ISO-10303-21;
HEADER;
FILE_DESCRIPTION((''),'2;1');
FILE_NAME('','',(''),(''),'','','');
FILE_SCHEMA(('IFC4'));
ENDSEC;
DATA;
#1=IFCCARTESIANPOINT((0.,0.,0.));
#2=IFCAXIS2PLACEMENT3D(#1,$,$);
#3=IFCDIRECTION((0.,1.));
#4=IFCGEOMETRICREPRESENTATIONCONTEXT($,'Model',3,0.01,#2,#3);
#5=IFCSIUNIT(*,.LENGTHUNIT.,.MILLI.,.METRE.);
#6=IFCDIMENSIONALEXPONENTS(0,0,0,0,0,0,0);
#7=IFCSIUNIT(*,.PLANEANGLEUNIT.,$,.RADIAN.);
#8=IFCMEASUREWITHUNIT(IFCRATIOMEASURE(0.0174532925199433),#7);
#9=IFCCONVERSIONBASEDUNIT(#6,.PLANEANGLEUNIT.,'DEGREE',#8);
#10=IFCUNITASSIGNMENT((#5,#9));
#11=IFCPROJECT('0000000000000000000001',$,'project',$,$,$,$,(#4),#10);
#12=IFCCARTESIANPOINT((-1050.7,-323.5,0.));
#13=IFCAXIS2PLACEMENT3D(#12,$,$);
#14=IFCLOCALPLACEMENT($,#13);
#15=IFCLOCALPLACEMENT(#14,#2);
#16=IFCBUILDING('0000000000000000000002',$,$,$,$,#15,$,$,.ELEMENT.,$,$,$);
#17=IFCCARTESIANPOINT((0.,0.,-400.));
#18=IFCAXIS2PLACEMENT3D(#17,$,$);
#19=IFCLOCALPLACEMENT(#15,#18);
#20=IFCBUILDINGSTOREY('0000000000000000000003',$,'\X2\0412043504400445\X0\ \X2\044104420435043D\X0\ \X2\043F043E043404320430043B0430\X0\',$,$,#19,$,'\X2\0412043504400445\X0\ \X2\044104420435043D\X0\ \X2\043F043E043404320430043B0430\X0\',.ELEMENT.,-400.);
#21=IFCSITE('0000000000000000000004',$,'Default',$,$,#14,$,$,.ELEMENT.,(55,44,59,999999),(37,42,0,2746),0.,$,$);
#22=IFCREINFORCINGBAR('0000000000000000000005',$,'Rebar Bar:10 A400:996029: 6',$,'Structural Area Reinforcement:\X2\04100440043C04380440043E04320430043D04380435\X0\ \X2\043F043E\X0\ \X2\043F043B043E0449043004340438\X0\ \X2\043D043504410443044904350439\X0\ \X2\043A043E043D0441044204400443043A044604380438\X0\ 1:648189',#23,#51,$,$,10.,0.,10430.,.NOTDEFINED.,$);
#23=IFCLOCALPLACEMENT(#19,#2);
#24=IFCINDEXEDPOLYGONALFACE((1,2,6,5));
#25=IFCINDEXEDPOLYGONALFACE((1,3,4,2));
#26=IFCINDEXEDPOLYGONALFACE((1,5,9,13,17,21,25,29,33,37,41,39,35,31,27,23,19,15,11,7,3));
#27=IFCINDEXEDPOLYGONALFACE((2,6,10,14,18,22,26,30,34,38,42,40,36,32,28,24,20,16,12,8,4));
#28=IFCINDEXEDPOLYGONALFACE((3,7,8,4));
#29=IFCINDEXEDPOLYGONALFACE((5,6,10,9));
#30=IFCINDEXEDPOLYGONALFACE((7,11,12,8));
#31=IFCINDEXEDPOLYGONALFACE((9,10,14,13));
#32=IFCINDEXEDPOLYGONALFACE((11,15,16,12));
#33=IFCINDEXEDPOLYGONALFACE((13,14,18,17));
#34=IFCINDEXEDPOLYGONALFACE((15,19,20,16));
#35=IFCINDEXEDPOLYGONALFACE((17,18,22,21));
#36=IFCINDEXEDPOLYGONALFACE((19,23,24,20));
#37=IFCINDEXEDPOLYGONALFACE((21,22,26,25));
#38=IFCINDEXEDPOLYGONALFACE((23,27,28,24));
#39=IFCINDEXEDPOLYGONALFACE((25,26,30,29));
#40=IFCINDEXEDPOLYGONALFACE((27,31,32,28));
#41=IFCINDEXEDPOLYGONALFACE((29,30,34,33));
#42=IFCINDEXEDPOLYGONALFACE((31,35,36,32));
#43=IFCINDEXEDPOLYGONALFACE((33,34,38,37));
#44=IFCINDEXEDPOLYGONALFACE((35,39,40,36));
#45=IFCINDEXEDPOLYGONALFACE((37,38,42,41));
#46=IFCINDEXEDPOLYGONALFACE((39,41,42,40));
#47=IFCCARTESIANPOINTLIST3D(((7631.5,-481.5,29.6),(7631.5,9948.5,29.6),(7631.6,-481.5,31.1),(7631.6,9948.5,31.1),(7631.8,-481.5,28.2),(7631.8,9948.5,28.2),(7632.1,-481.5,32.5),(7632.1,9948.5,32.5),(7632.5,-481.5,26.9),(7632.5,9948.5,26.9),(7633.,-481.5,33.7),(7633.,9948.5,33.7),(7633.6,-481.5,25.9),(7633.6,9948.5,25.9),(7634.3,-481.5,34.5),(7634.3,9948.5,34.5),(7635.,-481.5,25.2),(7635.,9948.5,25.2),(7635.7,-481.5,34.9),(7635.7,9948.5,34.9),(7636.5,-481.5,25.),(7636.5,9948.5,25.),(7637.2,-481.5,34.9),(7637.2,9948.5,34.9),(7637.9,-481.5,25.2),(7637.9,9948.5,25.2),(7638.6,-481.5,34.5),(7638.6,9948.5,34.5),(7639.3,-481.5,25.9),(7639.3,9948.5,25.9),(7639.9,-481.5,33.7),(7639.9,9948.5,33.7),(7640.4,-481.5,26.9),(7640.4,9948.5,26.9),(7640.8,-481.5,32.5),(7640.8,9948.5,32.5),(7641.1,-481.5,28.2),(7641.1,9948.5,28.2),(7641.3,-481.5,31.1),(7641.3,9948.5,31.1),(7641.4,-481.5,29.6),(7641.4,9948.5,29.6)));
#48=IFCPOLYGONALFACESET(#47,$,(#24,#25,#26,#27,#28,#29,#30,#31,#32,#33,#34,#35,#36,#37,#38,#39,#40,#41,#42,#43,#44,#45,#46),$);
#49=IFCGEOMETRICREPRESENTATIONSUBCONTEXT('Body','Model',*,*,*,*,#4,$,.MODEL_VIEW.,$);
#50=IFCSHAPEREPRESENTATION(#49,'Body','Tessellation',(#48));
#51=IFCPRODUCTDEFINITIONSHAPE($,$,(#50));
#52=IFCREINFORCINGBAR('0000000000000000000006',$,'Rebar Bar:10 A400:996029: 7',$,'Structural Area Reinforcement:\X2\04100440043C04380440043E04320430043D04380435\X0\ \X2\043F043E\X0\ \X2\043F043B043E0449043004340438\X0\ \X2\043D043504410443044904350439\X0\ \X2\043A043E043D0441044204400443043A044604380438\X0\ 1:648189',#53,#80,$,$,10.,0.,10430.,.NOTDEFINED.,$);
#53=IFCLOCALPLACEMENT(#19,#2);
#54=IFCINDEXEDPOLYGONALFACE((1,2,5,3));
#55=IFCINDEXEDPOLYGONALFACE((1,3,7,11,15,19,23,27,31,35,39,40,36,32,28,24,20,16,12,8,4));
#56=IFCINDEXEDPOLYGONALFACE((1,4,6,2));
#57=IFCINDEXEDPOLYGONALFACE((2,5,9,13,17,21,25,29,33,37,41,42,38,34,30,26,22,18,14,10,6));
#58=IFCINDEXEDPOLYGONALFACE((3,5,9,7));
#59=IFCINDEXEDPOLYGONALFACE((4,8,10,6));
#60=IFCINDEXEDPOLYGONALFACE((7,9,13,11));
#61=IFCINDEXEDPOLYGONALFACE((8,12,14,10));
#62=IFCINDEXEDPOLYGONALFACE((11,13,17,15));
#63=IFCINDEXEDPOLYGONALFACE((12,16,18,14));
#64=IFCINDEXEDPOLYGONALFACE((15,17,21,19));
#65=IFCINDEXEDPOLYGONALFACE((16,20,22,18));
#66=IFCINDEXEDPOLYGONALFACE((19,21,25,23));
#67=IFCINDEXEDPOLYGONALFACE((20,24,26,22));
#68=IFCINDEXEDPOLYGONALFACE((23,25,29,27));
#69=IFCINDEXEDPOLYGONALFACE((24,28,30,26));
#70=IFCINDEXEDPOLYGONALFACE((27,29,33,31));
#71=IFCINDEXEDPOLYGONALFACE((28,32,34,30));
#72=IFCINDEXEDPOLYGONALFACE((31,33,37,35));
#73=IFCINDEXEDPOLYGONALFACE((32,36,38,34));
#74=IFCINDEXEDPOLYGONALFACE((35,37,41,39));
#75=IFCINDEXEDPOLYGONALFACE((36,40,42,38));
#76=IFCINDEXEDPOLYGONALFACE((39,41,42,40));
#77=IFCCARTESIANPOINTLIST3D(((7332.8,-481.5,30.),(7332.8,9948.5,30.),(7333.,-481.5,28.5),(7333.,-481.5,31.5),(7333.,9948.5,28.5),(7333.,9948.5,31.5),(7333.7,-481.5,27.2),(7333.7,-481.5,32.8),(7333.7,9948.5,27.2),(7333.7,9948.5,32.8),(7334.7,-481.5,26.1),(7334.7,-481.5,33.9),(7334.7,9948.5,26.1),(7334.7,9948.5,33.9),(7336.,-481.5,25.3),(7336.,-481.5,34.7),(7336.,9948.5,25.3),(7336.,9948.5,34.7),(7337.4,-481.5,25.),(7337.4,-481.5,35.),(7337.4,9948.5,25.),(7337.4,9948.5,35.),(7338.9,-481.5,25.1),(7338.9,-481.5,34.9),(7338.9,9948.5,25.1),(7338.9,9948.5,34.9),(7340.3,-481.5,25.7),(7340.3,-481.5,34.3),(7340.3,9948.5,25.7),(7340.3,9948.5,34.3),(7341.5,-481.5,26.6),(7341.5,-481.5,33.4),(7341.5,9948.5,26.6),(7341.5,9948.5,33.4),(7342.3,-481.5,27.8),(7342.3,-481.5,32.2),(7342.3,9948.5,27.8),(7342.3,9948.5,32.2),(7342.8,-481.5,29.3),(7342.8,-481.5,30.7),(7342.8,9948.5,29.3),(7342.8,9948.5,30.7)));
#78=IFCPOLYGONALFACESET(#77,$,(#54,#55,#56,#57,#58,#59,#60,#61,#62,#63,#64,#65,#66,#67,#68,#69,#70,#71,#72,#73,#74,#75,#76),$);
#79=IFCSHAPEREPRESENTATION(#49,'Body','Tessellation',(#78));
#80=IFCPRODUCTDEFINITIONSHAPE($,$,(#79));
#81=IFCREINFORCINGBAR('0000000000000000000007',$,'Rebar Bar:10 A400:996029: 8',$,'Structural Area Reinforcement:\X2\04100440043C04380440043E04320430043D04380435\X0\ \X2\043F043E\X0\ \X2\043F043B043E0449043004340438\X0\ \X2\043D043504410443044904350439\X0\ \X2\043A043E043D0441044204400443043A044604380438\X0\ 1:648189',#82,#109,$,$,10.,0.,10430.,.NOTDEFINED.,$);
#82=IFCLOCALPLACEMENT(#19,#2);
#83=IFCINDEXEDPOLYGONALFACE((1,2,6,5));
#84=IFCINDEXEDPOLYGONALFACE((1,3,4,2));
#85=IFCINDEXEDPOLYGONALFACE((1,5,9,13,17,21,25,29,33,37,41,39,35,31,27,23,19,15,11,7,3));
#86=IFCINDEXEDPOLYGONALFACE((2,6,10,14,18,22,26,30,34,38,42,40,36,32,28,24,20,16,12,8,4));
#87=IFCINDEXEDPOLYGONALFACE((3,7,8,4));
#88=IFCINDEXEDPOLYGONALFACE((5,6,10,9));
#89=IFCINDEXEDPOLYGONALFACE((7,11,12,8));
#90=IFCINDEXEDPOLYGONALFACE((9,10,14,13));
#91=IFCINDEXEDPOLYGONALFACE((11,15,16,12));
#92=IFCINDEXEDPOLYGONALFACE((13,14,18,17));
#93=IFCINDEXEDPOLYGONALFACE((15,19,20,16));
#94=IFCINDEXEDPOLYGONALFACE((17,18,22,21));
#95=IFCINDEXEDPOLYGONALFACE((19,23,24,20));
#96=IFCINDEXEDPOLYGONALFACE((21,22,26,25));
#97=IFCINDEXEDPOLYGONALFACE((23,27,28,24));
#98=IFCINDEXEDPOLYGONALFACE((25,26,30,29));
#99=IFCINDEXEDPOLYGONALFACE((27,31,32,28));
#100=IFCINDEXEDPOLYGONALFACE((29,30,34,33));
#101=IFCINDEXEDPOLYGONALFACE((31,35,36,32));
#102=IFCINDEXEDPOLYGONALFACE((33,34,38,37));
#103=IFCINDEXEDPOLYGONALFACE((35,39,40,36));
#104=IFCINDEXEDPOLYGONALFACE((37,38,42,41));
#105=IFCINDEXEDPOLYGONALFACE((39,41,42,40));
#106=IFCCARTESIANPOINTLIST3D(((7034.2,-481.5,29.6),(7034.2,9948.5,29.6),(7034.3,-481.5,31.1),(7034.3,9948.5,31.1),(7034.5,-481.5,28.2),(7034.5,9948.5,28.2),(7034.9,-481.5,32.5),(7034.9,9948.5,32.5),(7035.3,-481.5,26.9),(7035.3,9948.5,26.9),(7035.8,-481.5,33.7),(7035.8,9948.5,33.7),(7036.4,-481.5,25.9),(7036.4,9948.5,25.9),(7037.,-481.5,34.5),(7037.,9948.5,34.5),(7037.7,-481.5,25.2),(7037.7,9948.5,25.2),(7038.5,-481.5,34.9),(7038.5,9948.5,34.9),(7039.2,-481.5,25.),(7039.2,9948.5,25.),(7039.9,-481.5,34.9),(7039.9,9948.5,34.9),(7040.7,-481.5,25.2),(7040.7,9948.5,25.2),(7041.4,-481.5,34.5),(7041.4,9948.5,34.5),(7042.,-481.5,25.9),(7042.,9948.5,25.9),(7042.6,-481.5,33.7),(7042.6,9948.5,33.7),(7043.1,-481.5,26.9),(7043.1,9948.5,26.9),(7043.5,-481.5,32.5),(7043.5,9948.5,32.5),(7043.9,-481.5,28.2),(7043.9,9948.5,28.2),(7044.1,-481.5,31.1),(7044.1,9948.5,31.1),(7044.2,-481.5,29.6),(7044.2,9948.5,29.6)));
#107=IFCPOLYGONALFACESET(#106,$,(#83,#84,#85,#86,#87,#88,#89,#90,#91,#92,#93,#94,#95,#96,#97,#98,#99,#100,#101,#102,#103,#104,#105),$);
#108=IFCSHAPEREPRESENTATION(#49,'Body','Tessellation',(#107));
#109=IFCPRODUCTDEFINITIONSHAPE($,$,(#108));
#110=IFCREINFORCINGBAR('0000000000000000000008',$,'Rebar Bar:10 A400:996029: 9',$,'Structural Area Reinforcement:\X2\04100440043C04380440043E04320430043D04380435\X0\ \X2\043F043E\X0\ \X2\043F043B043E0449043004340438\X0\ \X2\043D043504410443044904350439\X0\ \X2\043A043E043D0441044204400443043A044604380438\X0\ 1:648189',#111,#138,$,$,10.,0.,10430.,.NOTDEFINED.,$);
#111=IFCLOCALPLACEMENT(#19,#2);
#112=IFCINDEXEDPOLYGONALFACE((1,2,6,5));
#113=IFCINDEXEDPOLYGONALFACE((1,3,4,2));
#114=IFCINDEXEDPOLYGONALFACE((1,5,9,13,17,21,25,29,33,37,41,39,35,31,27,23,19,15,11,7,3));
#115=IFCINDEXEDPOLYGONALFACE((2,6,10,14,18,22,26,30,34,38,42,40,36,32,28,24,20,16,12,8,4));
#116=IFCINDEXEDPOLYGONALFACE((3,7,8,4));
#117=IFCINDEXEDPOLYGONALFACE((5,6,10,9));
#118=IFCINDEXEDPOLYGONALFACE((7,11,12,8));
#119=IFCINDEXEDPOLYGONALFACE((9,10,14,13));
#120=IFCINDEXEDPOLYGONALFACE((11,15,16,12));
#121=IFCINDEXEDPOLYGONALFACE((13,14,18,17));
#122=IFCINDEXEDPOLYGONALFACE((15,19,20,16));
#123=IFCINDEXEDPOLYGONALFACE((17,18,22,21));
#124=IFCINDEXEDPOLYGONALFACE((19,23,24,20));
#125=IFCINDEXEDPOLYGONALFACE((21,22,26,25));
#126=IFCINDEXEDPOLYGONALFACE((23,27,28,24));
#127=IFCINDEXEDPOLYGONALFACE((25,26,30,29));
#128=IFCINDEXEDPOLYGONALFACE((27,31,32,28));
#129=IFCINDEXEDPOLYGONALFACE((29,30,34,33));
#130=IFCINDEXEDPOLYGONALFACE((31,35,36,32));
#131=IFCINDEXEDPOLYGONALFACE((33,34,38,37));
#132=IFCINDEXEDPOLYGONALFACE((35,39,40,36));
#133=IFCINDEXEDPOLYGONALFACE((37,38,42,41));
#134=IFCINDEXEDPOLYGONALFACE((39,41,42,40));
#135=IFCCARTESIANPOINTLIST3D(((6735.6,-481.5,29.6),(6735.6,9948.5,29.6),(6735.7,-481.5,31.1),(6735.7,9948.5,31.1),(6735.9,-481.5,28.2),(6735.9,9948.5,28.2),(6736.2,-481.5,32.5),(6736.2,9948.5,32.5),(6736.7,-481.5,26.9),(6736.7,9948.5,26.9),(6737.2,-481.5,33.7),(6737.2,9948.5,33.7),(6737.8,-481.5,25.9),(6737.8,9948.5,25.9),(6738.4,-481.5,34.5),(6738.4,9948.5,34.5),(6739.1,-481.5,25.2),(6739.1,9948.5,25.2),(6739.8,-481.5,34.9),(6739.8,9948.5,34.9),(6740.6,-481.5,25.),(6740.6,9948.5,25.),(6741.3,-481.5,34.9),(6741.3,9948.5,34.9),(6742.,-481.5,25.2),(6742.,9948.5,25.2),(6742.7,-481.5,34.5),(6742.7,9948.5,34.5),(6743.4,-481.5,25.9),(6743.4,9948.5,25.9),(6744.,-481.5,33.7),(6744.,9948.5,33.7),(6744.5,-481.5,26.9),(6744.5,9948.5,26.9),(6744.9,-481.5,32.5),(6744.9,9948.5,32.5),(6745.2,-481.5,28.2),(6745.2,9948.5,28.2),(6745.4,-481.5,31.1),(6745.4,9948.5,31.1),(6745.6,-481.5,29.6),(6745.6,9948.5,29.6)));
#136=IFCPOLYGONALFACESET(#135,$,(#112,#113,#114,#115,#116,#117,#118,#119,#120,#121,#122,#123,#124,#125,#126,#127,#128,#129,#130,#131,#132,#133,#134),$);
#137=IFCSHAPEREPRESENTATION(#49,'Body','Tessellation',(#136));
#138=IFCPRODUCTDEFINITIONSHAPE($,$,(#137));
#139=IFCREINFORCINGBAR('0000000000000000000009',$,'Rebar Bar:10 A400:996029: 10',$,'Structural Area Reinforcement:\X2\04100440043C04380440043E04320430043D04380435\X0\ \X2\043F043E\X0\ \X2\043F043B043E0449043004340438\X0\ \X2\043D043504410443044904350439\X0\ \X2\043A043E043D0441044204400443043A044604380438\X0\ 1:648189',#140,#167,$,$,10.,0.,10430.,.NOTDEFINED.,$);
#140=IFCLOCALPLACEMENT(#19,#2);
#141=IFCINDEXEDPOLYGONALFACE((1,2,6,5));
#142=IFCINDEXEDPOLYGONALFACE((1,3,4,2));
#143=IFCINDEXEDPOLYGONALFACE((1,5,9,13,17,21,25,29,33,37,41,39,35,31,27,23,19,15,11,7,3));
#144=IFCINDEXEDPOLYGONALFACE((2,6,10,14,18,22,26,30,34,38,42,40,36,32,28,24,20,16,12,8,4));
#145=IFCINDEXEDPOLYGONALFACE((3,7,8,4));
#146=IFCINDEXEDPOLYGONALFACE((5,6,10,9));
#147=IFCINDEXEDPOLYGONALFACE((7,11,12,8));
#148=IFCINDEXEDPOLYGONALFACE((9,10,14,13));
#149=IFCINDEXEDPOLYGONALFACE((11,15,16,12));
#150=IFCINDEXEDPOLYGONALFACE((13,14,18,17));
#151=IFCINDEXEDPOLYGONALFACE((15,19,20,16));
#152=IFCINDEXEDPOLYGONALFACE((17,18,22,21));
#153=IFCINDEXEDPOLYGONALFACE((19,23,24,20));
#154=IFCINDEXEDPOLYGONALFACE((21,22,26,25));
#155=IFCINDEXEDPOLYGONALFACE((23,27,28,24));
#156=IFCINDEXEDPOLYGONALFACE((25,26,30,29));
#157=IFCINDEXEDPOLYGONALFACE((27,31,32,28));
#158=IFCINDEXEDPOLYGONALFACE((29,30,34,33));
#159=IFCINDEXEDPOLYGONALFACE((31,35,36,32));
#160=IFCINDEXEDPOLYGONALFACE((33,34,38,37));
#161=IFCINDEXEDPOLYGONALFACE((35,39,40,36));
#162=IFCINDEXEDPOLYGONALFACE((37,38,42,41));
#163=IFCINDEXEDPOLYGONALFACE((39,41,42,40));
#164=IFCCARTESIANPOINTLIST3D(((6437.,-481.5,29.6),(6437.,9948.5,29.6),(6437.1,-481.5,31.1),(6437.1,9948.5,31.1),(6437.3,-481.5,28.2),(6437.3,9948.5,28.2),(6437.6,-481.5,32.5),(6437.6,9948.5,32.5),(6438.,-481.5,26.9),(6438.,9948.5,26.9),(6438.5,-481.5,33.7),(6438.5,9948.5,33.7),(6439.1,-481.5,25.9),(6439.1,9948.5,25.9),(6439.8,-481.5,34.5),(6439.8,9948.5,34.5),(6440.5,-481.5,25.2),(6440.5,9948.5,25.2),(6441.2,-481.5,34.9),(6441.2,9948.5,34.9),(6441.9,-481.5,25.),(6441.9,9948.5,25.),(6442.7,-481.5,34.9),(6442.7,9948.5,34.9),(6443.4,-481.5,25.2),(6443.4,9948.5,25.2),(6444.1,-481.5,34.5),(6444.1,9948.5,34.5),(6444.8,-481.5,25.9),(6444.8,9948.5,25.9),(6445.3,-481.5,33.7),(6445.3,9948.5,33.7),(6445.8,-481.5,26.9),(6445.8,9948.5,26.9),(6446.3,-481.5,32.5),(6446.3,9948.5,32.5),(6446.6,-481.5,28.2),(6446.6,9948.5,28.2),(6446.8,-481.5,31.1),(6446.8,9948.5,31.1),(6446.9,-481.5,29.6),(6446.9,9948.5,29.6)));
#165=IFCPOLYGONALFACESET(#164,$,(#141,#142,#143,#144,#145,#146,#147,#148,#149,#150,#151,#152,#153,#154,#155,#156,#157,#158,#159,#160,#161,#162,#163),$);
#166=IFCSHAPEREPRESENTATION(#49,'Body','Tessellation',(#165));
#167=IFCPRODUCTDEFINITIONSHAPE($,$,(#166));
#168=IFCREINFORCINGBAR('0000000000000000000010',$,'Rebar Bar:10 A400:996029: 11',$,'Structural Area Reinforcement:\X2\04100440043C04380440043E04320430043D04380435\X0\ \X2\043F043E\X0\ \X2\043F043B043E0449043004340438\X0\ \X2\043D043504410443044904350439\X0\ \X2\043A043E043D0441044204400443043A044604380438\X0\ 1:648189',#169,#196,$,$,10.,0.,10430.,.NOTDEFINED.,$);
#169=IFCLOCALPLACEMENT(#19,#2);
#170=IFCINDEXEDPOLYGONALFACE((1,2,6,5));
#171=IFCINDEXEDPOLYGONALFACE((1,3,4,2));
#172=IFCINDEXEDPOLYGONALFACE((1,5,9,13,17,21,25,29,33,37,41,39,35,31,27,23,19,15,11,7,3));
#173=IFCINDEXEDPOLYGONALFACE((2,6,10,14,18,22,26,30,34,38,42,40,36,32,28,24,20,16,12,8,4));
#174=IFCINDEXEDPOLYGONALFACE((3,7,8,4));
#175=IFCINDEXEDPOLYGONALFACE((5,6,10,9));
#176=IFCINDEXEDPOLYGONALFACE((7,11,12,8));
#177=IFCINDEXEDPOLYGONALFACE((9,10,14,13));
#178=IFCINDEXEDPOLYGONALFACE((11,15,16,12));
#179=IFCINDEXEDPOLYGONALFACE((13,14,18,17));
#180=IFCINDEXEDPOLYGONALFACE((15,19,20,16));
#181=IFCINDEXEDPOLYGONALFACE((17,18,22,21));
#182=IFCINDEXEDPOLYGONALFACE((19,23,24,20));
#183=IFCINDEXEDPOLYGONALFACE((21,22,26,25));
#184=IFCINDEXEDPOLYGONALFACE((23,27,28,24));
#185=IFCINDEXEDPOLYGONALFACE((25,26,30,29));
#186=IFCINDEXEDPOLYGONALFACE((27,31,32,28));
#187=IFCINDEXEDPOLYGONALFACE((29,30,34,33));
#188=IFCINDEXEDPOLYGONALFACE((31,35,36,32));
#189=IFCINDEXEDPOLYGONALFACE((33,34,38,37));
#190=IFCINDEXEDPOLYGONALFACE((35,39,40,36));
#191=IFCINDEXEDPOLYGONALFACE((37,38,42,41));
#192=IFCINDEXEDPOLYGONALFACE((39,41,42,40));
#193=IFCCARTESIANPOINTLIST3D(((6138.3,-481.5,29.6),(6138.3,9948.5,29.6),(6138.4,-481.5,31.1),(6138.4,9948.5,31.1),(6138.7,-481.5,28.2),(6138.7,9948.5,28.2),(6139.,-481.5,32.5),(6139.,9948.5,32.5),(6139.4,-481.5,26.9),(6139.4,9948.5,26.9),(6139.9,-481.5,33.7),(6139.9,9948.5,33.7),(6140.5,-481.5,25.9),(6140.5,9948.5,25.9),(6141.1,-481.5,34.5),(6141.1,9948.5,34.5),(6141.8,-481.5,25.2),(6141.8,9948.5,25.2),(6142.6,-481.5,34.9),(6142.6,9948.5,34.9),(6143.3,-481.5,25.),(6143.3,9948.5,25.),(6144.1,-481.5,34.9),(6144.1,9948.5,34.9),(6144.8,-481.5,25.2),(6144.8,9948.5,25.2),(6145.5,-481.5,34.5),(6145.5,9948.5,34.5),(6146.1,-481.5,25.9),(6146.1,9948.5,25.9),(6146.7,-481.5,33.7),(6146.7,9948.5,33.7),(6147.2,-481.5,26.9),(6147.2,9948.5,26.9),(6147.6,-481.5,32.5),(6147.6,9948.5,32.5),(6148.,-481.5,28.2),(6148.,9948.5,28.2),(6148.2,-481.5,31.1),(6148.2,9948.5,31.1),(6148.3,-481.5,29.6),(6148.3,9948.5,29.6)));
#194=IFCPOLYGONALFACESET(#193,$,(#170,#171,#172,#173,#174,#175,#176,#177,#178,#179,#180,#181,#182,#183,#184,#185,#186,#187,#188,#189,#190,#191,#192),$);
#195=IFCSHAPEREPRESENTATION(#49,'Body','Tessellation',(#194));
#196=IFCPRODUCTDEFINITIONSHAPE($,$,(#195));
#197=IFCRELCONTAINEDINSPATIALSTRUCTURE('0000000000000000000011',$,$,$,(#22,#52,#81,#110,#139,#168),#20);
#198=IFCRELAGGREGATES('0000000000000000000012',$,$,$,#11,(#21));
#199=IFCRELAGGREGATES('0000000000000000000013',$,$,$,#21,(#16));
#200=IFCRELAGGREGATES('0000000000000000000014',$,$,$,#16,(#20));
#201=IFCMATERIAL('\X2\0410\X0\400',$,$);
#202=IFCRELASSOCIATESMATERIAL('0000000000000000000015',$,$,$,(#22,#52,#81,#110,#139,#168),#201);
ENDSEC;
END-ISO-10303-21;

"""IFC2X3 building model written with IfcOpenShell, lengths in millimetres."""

from ifc_helpers import new_model, entity, si_unit, converted_unit, direction, frame, origin, place, context, subcontext, project, spatial, material, element, save


model = new_model("IFC2X3")

# Units and contexts
model_context = context("Model", 3, precision=0.01, world=origin(), true_north=direction((0.0, 1.0)))
body_context = subcontext(model_context, "Body", "Model", "MODEL_VIEW")
ifc_project = project(units=[si_unit("LENGTHUNIT", "METRE", prefix="MILLI"), converted_unit("PLANEANGLEUNIT", "DEGREE", entity("IfcRatioMeasure", 0.0174532925199433), si_unit("PLANEANGLEUNIT", "RADIAN"), dimensions=[0, 0, 0, 0, 0, 0, 0])], contexts=[model_context])

# Site, building, storey
site_placement = place(None, frame((-1050.7, -323.5, 0.0)))
site = spatial("IfcSite", under=ifc_project, at=site_placement, Name="Default", CompositionType="ELEMENT", RefLatitude=(55, 44, 59, 999999), RefLongitude=(37, 42, 0, 2746), RefElevation=0.0)
building_placement = place(site_placement, origin())
building = spatial("IfcBuilding", under=site, at=building_placement, CompositionType="ELEMENT")
storey_placement = place(building_placement, frame((0.0, 0.0, -400.0)))
storey = spatial("IfcBuildingStorey", under=building, at=storey_placement, Name="Верх стен подвала", LongName="Верх стен подвала", CompositionType="ELEMENT", Elevation=-400.0)

# Reinforcing bars
ifc_material = material(Name="А400")
reinforcing_bar_1_placement = place(storey_placement, origin())
element("IfcReinforcingBar", 1, at=reinforcing_bar_1_placement, inside=storey, material=ifc_material, Name="Rebar Bar:10 A400:996029: 6", ObjectType="Structural Area Reinforcement:Армирование по площади несущей конструкции 1:648189", BarLength=10430.0, BarRole="NOTDEFINED", CrossSectionArea=0.0, NominalDiameter=10.0, context=body_context, shape_type="AdvancedSweptSolid", body=[
    entity("IfcSweptDiskSolid", entity("IfcCompositeCurve", [entity("IfcCompositeCurveSegment", "CONTINUOUS", True, entity("IfcPolyline", [entity("IfcCartesianPoint", [7636.5, 9948.5, 30.0]), entity("IfcCartesianPoint", [7636.5, -481.5, 30.0])]))], False), 5.0, None, 0.0, 1.0),
])
reinforcing_bar_2_placement = place(storey_placement, origin())
element("IfcReinforcingBar", 2, at=reinforcing_bar_2_placement, inside=storey, material=ifc_material, Name="Rebar Bar:10 A400:996029: 7", ObjectType="Structural Area Reinforcement:Армирование по площади несущей конструкции 1:648189", BarLength=10430.0, BarRole="NOTDEFINED", CrossSectionArea=0.0, NominalDiameter=10.0, context=body_context, shape_type="AdvancedSweptSolid", body=[
    entity("IfcSweptDiskSolid", entity("IfcCompositeCurve", [entity("IfcCompositeCurveSegment", "CONTINUOUS", True, entity("IfcPolyline", [entity("IfcCartesianPoint", [7337.8, 9948.5, 30.0]), entity("IfcCartesianPoint", [7337.8, -481.5, 30.0])]))], False), 5.0, None, 0.0, 1.0),
])
reinforcing_bar_3_placement = place(storey_placement, origin())
element("IfcReinforcingBar", 3, at=reinforcing_bar_3_placement, inside=storey, material=ifc_material, Name="Rebar Bar:10 A400:996029: 8", ObjectType="Structural Area Reinforcement:Армирование по площади несущей конструкции 1:648189", BarLength=10430.0, BarRole="NOTDEFINED", CrossSectionArea=0.0, NominalDiameter=10.0, context=body_context, shape_type="AdvancedSweptSolid", body=[
    entity("IfcSweptDiskSolid", entity("IfcCompositeCurve", [entity("IfcCompositeCurveSegment", "CONTINUOUS", True, entity("IfcPolyline", [entity("IfcCartesianPoint", [7039.2, 9948.5, 30.0]), entity("IfcCartesianPoint", [7039.2, -481.5, 30.0])]))], False), 5.0, None, 0.0, 1.0),
])
reinforcing_bar_4_placement = place(storey_placement, origin())
element("IfcReinforcingBar", 4, at=reinforcing_bar_4_placement, inside=storey, material=ifc_material, Name="Rebar Bar:10 A400:996029: 9", ObjectType="Structural Area Reinforcement:Армирование по площади несущей конструкции 1:648189", BarLength=10430.0, BarRole="NOTDEFINED", CrossSectionArea=0.0, NominalDiameter=10.0, context=body_context, shape_type="AdvancedSweptSolid", body=[
    entity("IfcSweptDiskSolid", entity("IfcCompositeCurve", [entity("IfcCompositeCurveSegment", "CONTINUOUS", True, entity("IfcPolyline", [entity("IfcCartesianPoint", [6740.6, 9948.5, 30.0]), entity("IfcCartesianPoint", [6740.6, -481.5, 30.0])]))], False), 5.0, None, 0.0, 1.0),
])
reinforcing_bar_5_placement = place(storey_placement, origin())
element("IfcReinforcingBar", 5, at=reinforcing_bar_5_placement, inside=storey, material=ifc_material, Name="Rebar Bar:10 A400:996029: 10", ObjectType="Structural Area Reinforcement:Армирование по площади несущей конструкции 1:648189", BarLength=10430.0, BarRole="NOTDEFINED", CrossSectionArea=0.0, NominalDiameter=10.0, context=body_context, shape_type="AdvancedSweptSolid", body=[
    entity("IfcSweptDiskSolid", entity("IfcCompositeCurve", [entity("IfcCompositeCurveSegment", "CONTINUOUS", True, entity("IfcPolyline", [entity("IfcCartesianPoint", [6441.9, 9948.5, 30.0]), entity("IfcCartesianPoint", [6441.9, -481.5, 30.0])]))], False), 5.0, None, 0.0, 1.0),
])
reinforcing_bar_6_placement = place(storey_placement, origin())
element("IfcReinforcingBar", 6, at=reinforcing_bar_6_placement, inside=storey, material=ifc_material, Name="Rebar Bar:10 A400:996029: 11", ObjectType="Structural Area Reinforcement:Армирование по площади несущей конструкции 1:648189", BarLength=10430.0, BarRole="NOTDEFINED", CrossSectionArea=0.0, NominalDiameter=10.0, context=body_context, shape_type="AdvancedSweptSolid", body=[
    entity("IfcSweptDiskSolid", entity("IfcCompositeCurve", [entity("IfcCompositeCurveSegment", "CONTINUOUS", True, entity("IfcPolyline", [entity("IfcCartesianPoint", [6143.3, 9948.5, 30.0]), entity("IfcCartesianPoint", [6143.3, -481.5, 30.0])]))], False), 5.0, None, 0.0, 1.0),
])

save(model, "model.ifc")
